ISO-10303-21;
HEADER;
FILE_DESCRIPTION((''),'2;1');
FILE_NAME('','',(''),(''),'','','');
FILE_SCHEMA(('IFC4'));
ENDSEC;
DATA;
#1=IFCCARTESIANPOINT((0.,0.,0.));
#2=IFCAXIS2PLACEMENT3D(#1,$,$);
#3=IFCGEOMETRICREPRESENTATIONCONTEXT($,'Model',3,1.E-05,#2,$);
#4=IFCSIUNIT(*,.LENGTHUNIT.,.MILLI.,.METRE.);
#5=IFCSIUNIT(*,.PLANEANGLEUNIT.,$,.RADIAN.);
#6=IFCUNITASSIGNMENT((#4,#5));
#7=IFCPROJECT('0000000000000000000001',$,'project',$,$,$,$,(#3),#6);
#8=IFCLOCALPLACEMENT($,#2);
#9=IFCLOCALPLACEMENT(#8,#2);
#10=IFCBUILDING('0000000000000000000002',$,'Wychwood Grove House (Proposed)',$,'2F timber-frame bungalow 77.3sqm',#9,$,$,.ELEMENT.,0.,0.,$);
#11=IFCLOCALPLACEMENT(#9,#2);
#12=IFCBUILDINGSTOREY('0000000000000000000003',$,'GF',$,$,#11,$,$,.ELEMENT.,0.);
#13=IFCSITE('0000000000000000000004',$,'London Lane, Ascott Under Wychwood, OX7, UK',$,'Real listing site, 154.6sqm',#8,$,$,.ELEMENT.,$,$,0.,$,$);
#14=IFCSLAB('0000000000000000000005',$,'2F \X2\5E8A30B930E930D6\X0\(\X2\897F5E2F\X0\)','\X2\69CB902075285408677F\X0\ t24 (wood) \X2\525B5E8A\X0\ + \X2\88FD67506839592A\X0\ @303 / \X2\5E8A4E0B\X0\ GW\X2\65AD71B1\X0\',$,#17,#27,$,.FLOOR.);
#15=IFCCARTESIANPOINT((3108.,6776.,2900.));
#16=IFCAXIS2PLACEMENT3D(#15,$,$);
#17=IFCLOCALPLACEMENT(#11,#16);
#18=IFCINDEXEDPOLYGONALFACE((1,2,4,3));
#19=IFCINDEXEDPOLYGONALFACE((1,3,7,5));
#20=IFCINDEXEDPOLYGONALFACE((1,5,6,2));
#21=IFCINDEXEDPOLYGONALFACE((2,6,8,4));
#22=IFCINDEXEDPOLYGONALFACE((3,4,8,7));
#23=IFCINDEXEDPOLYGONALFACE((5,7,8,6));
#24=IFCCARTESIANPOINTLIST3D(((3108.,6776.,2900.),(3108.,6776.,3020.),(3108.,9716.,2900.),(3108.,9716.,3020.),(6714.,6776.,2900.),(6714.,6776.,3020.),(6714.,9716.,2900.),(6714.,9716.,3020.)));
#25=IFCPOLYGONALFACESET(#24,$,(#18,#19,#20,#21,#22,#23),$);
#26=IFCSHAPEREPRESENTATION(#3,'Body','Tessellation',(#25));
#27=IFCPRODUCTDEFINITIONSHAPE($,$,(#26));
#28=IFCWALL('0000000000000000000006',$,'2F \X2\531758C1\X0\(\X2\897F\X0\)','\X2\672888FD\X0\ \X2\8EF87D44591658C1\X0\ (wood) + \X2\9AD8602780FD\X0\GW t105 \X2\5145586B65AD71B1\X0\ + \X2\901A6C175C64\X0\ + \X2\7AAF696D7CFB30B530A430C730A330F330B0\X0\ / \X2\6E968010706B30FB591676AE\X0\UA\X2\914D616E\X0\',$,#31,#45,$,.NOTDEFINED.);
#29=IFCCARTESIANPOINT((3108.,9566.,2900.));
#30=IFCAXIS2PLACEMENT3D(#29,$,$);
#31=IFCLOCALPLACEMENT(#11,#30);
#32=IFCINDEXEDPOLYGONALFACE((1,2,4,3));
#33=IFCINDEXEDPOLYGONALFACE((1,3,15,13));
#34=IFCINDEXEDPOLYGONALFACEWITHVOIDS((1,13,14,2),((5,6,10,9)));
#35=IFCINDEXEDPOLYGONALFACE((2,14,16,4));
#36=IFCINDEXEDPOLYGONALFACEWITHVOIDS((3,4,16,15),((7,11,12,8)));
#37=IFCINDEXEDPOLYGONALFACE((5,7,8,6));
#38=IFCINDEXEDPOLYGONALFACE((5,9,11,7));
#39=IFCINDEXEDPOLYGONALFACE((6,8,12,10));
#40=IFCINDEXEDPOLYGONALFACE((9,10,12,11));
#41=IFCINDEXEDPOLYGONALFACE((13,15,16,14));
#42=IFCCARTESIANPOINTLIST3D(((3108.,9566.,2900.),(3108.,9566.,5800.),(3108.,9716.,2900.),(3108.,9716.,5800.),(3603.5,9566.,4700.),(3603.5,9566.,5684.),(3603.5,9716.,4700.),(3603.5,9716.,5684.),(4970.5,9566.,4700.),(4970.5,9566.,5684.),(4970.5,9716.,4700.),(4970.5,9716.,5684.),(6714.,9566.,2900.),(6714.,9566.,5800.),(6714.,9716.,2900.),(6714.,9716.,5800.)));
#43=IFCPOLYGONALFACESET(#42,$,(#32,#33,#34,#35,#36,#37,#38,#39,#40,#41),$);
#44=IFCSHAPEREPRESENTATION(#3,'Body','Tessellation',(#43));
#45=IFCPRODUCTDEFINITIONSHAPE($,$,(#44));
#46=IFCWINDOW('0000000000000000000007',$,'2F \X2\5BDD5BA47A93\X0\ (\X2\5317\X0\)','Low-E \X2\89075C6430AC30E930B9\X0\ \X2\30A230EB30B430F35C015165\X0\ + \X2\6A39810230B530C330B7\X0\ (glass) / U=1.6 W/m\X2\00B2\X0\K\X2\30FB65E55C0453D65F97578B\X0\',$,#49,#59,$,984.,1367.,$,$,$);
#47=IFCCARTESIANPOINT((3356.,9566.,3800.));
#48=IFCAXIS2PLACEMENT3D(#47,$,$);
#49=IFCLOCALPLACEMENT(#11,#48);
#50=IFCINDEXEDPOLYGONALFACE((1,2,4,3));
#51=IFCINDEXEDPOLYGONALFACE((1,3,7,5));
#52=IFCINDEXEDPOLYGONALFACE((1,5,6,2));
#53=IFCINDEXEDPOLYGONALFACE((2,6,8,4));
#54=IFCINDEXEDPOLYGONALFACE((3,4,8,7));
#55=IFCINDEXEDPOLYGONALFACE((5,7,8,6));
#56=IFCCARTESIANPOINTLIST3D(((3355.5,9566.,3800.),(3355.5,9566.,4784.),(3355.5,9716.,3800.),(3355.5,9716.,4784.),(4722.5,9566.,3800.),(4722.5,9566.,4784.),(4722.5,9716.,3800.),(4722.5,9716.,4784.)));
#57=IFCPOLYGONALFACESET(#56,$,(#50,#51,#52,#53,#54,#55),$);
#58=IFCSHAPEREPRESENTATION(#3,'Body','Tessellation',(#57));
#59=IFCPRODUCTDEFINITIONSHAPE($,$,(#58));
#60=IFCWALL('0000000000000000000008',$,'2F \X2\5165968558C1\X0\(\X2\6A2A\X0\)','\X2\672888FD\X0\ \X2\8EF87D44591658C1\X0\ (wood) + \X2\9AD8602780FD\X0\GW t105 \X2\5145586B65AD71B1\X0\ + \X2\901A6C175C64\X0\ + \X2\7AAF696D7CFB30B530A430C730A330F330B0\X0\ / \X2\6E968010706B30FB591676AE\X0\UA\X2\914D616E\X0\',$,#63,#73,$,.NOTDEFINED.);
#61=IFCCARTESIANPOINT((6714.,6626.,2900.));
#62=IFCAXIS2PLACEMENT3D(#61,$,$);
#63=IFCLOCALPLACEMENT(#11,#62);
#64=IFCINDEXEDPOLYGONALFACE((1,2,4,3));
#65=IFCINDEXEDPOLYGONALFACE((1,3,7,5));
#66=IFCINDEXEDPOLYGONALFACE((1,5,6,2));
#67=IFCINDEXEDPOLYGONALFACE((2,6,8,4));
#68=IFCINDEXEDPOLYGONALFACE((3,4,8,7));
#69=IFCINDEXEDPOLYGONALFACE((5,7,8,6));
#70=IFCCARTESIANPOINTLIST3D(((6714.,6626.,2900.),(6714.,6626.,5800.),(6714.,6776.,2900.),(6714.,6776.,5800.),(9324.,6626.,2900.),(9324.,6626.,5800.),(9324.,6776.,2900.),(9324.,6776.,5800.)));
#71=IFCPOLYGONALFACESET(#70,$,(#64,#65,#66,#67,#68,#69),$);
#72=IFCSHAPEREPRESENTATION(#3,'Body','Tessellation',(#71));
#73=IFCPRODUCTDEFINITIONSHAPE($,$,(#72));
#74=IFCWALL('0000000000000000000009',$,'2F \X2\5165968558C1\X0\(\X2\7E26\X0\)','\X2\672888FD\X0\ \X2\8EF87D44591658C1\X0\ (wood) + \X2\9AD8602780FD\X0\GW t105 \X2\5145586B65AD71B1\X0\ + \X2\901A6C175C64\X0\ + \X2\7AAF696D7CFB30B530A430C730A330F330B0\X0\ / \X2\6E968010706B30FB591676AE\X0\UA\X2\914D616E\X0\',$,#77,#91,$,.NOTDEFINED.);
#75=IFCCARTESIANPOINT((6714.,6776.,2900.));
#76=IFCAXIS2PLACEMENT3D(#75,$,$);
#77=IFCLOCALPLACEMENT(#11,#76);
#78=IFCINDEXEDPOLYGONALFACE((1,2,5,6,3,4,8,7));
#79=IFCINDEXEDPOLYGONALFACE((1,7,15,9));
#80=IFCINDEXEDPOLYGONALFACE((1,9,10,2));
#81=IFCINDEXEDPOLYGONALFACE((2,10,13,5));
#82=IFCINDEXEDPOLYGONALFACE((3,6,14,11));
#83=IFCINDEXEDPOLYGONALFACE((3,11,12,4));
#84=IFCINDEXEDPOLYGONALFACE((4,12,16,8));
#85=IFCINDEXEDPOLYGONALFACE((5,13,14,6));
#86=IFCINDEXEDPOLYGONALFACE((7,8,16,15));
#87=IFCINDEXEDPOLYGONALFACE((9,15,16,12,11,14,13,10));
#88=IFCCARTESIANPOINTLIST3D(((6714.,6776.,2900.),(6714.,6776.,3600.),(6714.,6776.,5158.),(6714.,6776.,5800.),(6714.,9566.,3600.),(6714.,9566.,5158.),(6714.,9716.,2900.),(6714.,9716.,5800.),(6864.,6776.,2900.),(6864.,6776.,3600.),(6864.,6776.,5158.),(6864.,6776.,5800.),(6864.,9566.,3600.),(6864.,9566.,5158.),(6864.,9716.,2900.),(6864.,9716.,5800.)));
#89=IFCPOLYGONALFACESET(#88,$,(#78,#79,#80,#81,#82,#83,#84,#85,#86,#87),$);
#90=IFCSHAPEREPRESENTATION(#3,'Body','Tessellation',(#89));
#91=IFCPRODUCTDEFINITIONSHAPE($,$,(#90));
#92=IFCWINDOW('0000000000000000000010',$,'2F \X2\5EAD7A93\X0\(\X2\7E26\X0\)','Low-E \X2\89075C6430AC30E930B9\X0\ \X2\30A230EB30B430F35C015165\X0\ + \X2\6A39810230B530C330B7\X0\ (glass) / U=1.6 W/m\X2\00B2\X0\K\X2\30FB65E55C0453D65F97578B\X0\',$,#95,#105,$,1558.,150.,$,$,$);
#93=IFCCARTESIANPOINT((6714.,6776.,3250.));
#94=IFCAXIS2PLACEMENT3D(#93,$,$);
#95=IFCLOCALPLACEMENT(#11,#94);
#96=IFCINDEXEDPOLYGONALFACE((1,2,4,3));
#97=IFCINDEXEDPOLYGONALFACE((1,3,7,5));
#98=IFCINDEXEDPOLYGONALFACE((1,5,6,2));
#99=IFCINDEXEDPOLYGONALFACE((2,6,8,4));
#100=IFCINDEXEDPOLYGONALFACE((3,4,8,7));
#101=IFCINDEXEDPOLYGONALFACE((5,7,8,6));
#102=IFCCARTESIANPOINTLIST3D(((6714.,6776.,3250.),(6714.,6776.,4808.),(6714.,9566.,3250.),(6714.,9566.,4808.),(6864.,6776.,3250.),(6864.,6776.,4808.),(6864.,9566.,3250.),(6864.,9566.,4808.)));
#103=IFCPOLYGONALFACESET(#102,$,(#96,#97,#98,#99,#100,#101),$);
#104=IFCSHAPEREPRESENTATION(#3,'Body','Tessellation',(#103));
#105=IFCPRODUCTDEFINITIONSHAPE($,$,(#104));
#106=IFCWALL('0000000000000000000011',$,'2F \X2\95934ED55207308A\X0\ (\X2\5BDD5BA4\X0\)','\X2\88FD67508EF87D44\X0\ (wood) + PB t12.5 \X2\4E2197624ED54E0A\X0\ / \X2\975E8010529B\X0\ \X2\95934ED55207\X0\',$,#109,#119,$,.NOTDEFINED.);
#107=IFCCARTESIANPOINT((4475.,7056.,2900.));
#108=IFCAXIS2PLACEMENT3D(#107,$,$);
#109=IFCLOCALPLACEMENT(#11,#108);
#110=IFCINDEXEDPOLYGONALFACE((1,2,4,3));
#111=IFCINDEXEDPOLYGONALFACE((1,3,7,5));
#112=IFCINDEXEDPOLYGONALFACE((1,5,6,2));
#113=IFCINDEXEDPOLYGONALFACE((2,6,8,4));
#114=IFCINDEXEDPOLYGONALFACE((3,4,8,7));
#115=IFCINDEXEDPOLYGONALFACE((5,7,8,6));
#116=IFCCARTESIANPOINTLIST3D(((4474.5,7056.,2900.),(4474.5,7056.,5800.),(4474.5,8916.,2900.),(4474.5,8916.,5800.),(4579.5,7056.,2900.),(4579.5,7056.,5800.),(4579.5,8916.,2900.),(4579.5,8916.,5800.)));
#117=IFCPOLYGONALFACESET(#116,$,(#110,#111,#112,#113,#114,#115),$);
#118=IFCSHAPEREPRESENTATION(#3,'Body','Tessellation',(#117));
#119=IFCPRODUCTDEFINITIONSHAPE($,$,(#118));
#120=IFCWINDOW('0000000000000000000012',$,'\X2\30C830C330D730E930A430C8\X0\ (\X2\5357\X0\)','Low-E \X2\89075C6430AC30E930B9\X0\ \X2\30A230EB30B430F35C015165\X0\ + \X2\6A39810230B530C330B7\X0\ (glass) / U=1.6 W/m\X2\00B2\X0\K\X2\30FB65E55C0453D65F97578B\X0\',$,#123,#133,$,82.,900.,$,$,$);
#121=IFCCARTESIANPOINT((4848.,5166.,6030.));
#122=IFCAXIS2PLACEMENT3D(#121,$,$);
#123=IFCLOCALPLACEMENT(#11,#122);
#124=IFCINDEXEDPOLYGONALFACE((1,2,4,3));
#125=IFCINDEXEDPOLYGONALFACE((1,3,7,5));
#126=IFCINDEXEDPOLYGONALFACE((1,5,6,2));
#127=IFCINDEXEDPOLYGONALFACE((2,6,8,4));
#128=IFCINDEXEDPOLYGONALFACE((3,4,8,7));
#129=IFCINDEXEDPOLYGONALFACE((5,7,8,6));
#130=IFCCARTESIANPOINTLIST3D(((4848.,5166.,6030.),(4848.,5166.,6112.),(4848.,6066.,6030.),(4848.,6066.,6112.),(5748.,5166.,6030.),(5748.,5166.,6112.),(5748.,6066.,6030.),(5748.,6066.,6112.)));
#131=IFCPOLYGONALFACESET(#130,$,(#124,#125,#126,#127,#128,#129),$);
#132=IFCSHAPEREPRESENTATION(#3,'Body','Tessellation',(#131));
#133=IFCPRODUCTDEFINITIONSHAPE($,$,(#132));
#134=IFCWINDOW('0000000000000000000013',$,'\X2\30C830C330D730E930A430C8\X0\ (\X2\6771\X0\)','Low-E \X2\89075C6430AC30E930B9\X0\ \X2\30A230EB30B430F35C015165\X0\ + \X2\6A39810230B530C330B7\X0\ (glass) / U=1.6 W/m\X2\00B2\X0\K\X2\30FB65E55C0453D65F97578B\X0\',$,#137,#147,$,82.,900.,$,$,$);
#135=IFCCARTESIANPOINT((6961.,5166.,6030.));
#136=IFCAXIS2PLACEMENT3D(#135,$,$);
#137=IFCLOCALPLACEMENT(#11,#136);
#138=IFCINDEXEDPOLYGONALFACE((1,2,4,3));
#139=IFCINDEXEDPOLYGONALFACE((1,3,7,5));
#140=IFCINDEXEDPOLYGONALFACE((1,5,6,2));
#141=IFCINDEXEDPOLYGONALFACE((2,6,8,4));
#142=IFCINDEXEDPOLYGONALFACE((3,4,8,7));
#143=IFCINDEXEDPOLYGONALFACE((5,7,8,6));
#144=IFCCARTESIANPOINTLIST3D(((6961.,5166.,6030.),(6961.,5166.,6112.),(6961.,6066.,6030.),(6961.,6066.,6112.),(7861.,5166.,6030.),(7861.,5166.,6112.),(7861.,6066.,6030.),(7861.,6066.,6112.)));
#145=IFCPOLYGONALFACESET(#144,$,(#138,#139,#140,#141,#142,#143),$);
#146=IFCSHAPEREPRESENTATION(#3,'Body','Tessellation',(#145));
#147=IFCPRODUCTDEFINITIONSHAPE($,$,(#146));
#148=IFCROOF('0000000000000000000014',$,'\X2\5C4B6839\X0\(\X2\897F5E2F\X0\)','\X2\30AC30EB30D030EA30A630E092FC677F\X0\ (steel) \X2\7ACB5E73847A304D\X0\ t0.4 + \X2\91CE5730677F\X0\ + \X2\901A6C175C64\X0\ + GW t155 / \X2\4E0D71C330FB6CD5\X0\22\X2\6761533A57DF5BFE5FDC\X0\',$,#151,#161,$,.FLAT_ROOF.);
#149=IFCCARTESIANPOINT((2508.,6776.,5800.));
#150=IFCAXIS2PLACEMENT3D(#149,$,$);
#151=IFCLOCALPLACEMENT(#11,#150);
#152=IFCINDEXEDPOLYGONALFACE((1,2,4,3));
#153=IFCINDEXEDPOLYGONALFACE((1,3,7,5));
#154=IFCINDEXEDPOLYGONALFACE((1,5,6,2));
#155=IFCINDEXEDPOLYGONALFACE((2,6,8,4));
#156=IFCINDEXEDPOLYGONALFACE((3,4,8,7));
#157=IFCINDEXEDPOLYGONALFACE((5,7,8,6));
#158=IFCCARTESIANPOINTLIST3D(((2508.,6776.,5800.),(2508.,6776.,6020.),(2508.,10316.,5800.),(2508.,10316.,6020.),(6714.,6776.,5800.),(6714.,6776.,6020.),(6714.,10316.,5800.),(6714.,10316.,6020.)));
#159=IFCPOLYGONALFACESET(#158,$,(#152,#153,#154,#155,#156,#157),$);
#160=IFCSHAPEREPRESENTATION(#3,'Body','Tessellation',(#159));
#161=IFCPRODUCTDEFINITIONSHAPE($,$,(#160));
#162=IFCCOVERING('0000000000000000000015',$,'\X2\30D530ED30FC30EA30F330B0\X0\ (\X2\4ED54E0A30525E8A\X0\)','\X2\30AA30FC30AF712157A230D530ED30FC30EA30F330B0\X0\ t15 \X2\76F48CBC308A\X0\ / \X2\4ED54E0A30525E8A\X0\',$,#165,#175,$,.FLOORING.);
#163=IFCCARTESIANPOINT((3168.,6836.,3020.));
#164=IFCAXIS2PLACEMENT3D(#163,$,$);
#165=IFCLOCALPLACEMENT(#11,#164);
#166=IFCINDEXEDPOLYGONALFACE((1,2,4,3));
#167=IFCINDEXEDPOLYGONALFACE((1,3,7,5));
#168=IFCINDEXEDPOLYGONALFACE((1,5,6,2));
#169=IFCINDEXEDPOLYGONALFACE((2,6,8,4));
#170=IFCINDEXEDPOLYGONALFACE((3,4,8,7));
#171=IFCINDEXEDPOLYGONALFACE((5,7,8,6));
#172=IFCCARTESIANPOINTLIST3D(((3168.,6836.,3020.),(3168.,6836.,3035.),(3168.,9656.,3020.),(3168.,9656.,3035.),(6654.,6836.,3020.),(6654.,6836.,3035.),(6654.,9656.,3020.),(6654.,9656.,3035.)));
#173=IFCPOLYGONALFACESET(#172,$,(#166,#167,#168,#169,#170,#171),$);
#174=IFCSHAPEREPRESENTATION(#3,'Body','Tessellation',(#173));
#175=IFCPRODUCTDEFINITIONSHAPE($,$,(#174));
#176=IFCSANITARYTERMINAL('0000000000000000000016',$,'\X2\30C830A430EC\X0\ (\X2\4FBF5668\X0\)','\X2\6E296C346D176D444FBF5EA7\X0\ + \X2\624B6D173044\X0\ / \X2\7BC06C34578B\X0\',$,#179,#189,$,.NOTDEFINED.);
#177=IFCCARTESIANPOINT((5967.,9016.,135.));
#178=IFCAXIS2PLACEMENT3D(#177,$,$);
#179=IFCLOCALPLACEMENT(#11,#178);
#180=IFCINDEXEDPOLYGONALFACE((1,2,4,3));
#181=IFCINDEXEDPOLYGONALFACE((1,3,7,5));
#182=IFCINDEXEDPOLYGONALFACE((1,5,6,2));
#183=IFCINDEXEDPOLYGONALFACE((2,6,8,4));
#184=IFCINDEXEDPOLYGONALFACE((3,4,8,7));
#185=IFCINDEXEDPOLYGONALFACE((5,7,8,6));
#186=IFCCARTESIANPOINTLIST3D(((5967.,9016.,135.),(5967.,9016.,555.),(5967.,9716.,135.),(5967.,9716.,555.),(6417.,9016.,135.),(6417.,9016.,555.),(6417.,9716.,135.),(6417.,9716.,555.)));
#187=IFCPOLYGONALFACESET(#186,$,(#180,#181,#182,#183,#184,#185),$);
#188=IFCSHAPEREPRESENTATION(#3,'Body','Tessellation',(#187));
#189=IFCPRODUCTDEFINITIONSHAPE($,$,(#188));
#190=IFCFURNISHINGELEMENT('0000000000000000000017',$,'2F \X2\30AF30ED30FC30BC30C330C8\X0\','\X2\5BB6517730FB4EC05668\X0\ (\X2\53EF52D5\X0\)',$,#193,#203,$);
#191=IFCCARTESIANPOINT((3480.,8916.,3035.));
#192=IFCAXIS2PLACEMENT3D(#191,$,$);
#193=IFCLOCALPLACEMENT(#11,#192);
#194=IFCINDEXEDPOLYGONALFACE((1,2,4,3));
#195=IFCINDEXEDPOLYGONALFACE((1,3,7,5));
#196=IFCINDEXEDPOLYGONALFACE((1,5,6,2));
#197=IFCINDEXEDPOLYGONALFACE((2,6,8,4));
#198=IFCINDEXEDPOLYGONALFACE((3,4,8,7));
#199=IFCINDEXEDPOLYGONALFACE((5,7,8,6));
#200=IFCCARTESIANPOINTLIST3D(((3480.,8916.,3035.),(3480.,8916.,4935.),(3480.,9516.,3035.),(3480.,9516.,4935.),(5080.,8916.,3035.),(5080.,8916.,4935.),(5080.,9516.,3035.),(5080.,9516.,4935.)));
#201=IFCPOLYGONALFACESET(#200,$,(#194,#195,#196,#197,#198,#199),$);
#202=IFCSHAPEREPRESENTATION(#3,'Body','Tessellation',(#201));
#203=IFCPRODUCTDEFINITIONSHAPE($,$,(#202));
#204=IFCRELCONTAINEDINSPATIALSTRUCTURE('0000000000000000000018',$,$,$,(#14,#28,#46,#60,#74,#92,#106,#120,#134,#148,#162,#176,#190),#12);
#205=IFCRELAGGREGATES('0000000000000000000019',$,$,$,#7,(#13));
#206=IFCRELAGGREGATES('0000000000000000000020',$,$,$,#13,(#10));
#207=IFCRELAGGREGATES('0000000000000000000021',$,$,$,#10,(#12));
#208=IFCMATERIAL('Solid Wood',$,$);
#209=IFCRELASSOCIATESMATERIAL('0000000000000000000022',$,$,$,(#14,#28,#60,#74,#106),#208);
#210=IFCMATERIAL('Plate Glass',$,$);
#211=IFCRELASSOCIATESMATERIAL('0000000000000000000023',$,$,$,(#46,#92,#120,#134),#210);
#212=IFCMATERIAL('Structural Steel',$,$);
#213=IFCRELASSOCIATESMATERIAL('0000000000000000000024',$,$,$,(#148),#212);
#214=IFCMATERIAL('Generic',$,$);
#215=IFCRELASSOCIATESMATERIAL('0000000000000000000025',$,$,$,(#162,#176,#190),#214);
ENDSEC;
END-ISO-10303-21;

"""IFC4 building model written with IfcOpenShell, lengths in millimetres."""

from ifc_helpers import new_model, si_unit, frame, frame_2d, origin, place, context, project, spatial, rectangle, extrude, material, element, fill, save


model = new_model("IFC4")

# Units and contexts
model_context = context("Model", 3, precision=1e-05, world=origin())
ifc_project = project(units=[si_unit("LENGTHUNIT", "METRE", prefix="MILLI"), si_unit("PLANEANGLEUNIT", "RADIAN")], contexts=[model_context])

# Site, building, storey
site_placement = place(None, origin())
site = spatial("IfcSite", under=ifc_project, at=site_placement, Name="London Lane, Ascott Under Wychwood, OX7, UK", ObjectType="Real listing site, 154.6sqm", CompositionType="ELEMENT", RefElevation=0.0)
building_placement = place(site_placement, origin())
building = spatial("IfcBuilding", under=site, at=building_placement, Name="Wychwood Grove House (Proposed)", ObjectType="2F timber-frame bungalow 77.3sqm", CompositionType="ELEMENT", ElevationOfRefHeight=0.0, ElevationOfTerrain=0.0)
storey_placement = place(building_placement, origin())
storey = spatial("IfcBuildingStorey", under=building, at=storey_placement, Name="GF", CompositionType="ELEMENT", Elevation=0.0)

# Slab
ifc_material_1 = material(Name="Solid Wood")
slab_placement = place(storey_placement, frame((3108.0, 6776.0, 2900.0)))
element("IfcSlab", 1, at=slab_placement, inside=storey, material=ifc_material_1, Name="2F 床スラブ(西帯)", Description="構造用合板 t24 (wood) 剛床 + 製材根太 @303 / 床下 GW断熱", PredefinedType="FLOOR", context=model_context, shape_type="SweptSolid", body=[
    extrude(rectangle(XDim=3606.0, YDim=2940.0, at=frame_2d((1803.0, 1470.0))), frame((3108.0, 6776.0, 2900.0)), (0.0, 0.0, 1.0), 120.0),
])

# Wall, opening, window
wall_1_placement = place(storey_placement, frame((3108.0, 9566.0, 2900.0)))
wall_1 = element("IfcWall", 2, at=wall_1_placement, inside=storey, material=ifc_material_1, Name="2F 北壁(西)", Description="木製 軸組外壁 (wood) + 高性能GW t105 充填断熱 + 通気層 + 窯業系サイディング / 準耐火・外皮UA配慮", PredefinedType="NOTDEFINED", context=model_context, shape_type="SweptSolid", body=[
    extrude(rectangle(XDim=3606.0, YDim=150.0, at=frame_2d((1803.0, 75.0))), frame((3108.0, 9566.0, 2900.0)), (0.0, 0.0, 1.0), 2900.0),
])
opening_1_placement = place(storey_placement, frame((3356.0, 9566.0, 3800.0)))
opening_1 = element("IfcOpeningElement", 3, at=opening_1_placement, cuts=wall_1, PredefinedType="NOTDEFINED", context=model_context, shape_type="SweptSolid", body=[
    extrude(rectangle(XDim=1367.0, YDim=150.0, at=frame_2d((683.0, 75.0))), frame((3356.0, 9566.0, 3800.0)), (0.0, 0.0, 1.0), 984.0),
])
ifc_material_2 = material(Name="Plate Glass")
window_1_placement = place(storey_placement, frame((3356.0, 9566.0, 3800.0)))
window_1 = element("IfcWindow", 4, at=window_1_placement, inside=storey, material=ifc_material_2, Name="2F 寝室窓 (北)", Description="Low-E 複層ガラス アルゴン封入 + 樹脂サッシ (glass) / U=1.6 W/m²K・日射取得型", OverallHeight=984.0, OverallWidth=1367.0, context=model_context, shape_type="SweptSolid", body=[
    extrude(rectangle(XDim=1367.0, YDim=150.0, at=frame_2d((683.0, 75.0))), frame((3356.0, 9566.0, 3800.0)), (0.0, 0.0, 1.0), 984.0),
])
fill(opening_1, window_1)

# Wall
wall_2_placement = place(storey_placement, frame((6714.0, 6626.0, 2900.0)))
element("IfcWall", 5, at=wall_2_placement, inside=storey, material=ifc_material_1, Name="2F 入隅壁(横)", Description="木製 軸組外壁 (wood) + 高性能GW t105 充填断熱 + 通気層 + 窯業系サイディング / 準耐火・外皮UA配慮", PredefinedType="NOTDEFINED", context=model_context, shape_type="SweptSolid", body=[
    extrude(rectangle(XDim=2610.0, YDim=150.0, at=frame_2d((1305.0, 75.0))), frame((6714.0, 6626.0, 2900.0)), (0.0, 0.0, 1.0), 2900.0),
])

# Wall, opening, window
wall_3_placement = place(storey_placement, frame((6714.0, 6776.0, 2900.0)))
wall_3 = element("IfcWall", 6, at=wall_3_placement, inside=storey, material=ifc_material_1, Name="2F 入隅壁(縦)", Description="木製 軸組外壁 (wood) + 高性能GW t105 充填断熱 + 通気層 + 窯業系サイディング / 準耐火・外皮UA配慮", PredefinedType="NOTDEFINED", context=model_context, shape_type="SweptSolid", body=[
    extrude(rectangle(XDim=150.0, YDim=2940.0, at=frame_2d((75.0, 1470.0))), frame((6714.0, 6776.0, 2900.0)), (0.0, 0.0, 1.0), 2900.0),
])
opening_2_placement = place(storey_placement, frame((6714.0, 6776.0, 3250.0)))
opening_2 = element("IfcOpeningElement", 7, at=opening_2_placement, cuts=wall_3, PredefinedType="NOTDEFINED", context=model_context, shape_type="SweptSolid", body=[
    extrude(rectangle(XDim=150.0, YDim=2790.0, at=frame_2d((75.0, 1395.0))), frame((6714.0, 6776.0, 3250.0)), (0.0, 0.0, 1.0), 1558.0),
])
window_2_placement = place(storey_placement, frame((6714.0, 6776.0, 3250.0)))
window_2 = element("IfcWindow", 8, at=window_2_placement, inside=storey, material=ifc_material_2, Name="2F 庭窓(縦)", Description="Low-E 複層ガラス アルゴン封入 + 樹脂サッシ (glass) / U=1.6 W/m²K・日射取得型", OverallHeight=1558.0, OverallWidth=150.0, context=model_context, shape_type="SweptSolid", body=[
    extrude(rectangle(XDim=150.0, YDim=2790.0, at=frame_2d((75.0, 1395.0))), frame((6714.0, 6776.0, 3250.0)), (0.0, 0.0, 1.0), 1558.0),
])
fill(opening_2, window_2)

# Wall
wall_4_placement = place(storey_placement, frame((4475.0, 7056.0, 2900.0)))
element("IfcWall", 9, at=wall_4_placement, inside=storey, material=ifc_material_1, Name="2F 間仕切り (寝室)", Description="製材軸組 (wood) + PB t12.5 両面仕上 / 非耐力 間仕切", PredefinedType="NOTDEFINED", context=model_context, shape_type="SweptSolid", body=[
    extrude(rectangle(XDim=105.0, YDim=1860.0, at=frame_2d((52.0, 930.0))), frame((4475.0, 7056.0, 2900.0)), (0.0, 0.0, 1.0), 2900.0),
])

# Windows
window_3_placement = place(storey_placement, frame((4848.0, 5166.0, 6030.0)))
element("IfcWindow", 10, at=window_3_placement, inside=storey, material=ifc_material_2, Name="トップライト (南)", Description="Low-E 複層ガラス アルゴン封入 + 樹脂サッシ (glass) / U=1.6 W/m²K・日射取得型", OverallHeight=82.0, OverallWidth=900.0, context=model_context, shape_type="SweptSolid", body=[
    extrude(rectangle(XDim=900.0, YDim=900.0, at=frame_2d((450.0, 450.0))), frame((4848.0, 5166.0, 6030.0)), (0.0, 0.0, 1.0), 82.0),
])
window_4_placement = place(storey_placement, frame((6961.0, 5166.0, 6030.0)))
element("IfcWindow", 11, at=window_4_placement, inside=storey, material=ifc_material_2, Name="トップライト (東)", Description="Low-E 複層ガラス アルゴン封入 + 樹脂サッシ (glass) / U=1.6 W/m²K・日射取得型", OverallHeight=82.0, OverallWidth=900.0, context=model_context, shape_type="SweptSolid", body=[
    extrude(rectangle(XDim=900.0, YDim=900.0, at=frame_2d((450.0, 450.0))), frame((6961.0, 5166.0, 6030.0)), (0.0, 0.0, 1.0), 82.0),
])

# Roof
ifc_material_3 = material(Name="Structural Steel")
for number, where, name in (
    (12, (2508.0, 6776.0, 5800.0), "屋根(西帯)"),
):
    element("IfcRoof", number, at=place(storey_placement, frame(where)), inside=storey, material=ifc_material_3, Name=name, Description="ガルバリウム鋼板 (steel) 立平葺き t0.4 + 野地板 + 通気層 + GW t155 / 不燃・法22条区域対応", PredefinedType="FLAT_ROOF", context=model_context, shape_type="SweptSolid", body=[
        extrude(rectangle(XDim=4206.0, YDim=3540.0, at=frame_2d((2103.0, 1770.0))), frame((2508.0, 6776.0, 5800.0)), (0.0, 0.0, 1.0), 220.0),
    ])

# Covering
ifc_material_4 = material(Name="Generic")
covering_placement = place(storey_placement, frame((3168.0, 6836.0, 3020.0)))
element("IfcCovering", 13, at=covering_placement, inside=storey, material=ifc_material_4, Name="フローリング (仕上げ床)", Description="オーク無垢フローリング t15 直貼り / 仕上げ床", PredefinedType="FLOORING", context=model_context, shape_type="SweptSolid", body=[
    extrude(rectangle(XDim=3486.0, YDim=2820.0, at=frame_2d((1743.0, 1410.0))), frame((3168.0, 6836.0, 3020.0)), (0.0, 0.0, 1.0), 15.0),
])

# Sanitary terminal
sanitary_terminal_placement = place(storey_placement, frame((5967.0, 9016.0, 135.0)))
element("IfcSanitaryTerminal", 14, at=sanitary_terminal_placement, inside=storey, material=ifc_material_4, Name="トイレ (便器)", Description="温水洗浄便座 + 手洗い / 節水型", PredefinedType="NOTDEFINED", context=model_context, shape_type="SweptSolid", body=[
    extrude(rectangle(XDim=450.0, YDim=700.0, at=frame_2d((225.0, 350.0))), frame((5967.0, 9016.0, 135.0)), (0.0, 0.0, 1.0), 420.0),
])

# Furnishing element
furnishing_1_placement = place(storey_placement, frame((3480.0, 8916.0, 3035.0)))
element("IfcFurnishingElement", 15, at=furnishing_1_placement, inside=storey, material=ifc_material_4, Name="2F クローゼット", Description="家具・什器 (可動)", context=model_context, shape_type="SweptSolid", body=[
    extrude(rectangle(XDim=1600.0, YDim=600.0, at=frame_2d((800.0, 300.0))), frame((3480.0, 8916.0, 3035.0)), (0.0, 0.0, 1.0), 1900.0),
])

save(model, "model.ifc")
